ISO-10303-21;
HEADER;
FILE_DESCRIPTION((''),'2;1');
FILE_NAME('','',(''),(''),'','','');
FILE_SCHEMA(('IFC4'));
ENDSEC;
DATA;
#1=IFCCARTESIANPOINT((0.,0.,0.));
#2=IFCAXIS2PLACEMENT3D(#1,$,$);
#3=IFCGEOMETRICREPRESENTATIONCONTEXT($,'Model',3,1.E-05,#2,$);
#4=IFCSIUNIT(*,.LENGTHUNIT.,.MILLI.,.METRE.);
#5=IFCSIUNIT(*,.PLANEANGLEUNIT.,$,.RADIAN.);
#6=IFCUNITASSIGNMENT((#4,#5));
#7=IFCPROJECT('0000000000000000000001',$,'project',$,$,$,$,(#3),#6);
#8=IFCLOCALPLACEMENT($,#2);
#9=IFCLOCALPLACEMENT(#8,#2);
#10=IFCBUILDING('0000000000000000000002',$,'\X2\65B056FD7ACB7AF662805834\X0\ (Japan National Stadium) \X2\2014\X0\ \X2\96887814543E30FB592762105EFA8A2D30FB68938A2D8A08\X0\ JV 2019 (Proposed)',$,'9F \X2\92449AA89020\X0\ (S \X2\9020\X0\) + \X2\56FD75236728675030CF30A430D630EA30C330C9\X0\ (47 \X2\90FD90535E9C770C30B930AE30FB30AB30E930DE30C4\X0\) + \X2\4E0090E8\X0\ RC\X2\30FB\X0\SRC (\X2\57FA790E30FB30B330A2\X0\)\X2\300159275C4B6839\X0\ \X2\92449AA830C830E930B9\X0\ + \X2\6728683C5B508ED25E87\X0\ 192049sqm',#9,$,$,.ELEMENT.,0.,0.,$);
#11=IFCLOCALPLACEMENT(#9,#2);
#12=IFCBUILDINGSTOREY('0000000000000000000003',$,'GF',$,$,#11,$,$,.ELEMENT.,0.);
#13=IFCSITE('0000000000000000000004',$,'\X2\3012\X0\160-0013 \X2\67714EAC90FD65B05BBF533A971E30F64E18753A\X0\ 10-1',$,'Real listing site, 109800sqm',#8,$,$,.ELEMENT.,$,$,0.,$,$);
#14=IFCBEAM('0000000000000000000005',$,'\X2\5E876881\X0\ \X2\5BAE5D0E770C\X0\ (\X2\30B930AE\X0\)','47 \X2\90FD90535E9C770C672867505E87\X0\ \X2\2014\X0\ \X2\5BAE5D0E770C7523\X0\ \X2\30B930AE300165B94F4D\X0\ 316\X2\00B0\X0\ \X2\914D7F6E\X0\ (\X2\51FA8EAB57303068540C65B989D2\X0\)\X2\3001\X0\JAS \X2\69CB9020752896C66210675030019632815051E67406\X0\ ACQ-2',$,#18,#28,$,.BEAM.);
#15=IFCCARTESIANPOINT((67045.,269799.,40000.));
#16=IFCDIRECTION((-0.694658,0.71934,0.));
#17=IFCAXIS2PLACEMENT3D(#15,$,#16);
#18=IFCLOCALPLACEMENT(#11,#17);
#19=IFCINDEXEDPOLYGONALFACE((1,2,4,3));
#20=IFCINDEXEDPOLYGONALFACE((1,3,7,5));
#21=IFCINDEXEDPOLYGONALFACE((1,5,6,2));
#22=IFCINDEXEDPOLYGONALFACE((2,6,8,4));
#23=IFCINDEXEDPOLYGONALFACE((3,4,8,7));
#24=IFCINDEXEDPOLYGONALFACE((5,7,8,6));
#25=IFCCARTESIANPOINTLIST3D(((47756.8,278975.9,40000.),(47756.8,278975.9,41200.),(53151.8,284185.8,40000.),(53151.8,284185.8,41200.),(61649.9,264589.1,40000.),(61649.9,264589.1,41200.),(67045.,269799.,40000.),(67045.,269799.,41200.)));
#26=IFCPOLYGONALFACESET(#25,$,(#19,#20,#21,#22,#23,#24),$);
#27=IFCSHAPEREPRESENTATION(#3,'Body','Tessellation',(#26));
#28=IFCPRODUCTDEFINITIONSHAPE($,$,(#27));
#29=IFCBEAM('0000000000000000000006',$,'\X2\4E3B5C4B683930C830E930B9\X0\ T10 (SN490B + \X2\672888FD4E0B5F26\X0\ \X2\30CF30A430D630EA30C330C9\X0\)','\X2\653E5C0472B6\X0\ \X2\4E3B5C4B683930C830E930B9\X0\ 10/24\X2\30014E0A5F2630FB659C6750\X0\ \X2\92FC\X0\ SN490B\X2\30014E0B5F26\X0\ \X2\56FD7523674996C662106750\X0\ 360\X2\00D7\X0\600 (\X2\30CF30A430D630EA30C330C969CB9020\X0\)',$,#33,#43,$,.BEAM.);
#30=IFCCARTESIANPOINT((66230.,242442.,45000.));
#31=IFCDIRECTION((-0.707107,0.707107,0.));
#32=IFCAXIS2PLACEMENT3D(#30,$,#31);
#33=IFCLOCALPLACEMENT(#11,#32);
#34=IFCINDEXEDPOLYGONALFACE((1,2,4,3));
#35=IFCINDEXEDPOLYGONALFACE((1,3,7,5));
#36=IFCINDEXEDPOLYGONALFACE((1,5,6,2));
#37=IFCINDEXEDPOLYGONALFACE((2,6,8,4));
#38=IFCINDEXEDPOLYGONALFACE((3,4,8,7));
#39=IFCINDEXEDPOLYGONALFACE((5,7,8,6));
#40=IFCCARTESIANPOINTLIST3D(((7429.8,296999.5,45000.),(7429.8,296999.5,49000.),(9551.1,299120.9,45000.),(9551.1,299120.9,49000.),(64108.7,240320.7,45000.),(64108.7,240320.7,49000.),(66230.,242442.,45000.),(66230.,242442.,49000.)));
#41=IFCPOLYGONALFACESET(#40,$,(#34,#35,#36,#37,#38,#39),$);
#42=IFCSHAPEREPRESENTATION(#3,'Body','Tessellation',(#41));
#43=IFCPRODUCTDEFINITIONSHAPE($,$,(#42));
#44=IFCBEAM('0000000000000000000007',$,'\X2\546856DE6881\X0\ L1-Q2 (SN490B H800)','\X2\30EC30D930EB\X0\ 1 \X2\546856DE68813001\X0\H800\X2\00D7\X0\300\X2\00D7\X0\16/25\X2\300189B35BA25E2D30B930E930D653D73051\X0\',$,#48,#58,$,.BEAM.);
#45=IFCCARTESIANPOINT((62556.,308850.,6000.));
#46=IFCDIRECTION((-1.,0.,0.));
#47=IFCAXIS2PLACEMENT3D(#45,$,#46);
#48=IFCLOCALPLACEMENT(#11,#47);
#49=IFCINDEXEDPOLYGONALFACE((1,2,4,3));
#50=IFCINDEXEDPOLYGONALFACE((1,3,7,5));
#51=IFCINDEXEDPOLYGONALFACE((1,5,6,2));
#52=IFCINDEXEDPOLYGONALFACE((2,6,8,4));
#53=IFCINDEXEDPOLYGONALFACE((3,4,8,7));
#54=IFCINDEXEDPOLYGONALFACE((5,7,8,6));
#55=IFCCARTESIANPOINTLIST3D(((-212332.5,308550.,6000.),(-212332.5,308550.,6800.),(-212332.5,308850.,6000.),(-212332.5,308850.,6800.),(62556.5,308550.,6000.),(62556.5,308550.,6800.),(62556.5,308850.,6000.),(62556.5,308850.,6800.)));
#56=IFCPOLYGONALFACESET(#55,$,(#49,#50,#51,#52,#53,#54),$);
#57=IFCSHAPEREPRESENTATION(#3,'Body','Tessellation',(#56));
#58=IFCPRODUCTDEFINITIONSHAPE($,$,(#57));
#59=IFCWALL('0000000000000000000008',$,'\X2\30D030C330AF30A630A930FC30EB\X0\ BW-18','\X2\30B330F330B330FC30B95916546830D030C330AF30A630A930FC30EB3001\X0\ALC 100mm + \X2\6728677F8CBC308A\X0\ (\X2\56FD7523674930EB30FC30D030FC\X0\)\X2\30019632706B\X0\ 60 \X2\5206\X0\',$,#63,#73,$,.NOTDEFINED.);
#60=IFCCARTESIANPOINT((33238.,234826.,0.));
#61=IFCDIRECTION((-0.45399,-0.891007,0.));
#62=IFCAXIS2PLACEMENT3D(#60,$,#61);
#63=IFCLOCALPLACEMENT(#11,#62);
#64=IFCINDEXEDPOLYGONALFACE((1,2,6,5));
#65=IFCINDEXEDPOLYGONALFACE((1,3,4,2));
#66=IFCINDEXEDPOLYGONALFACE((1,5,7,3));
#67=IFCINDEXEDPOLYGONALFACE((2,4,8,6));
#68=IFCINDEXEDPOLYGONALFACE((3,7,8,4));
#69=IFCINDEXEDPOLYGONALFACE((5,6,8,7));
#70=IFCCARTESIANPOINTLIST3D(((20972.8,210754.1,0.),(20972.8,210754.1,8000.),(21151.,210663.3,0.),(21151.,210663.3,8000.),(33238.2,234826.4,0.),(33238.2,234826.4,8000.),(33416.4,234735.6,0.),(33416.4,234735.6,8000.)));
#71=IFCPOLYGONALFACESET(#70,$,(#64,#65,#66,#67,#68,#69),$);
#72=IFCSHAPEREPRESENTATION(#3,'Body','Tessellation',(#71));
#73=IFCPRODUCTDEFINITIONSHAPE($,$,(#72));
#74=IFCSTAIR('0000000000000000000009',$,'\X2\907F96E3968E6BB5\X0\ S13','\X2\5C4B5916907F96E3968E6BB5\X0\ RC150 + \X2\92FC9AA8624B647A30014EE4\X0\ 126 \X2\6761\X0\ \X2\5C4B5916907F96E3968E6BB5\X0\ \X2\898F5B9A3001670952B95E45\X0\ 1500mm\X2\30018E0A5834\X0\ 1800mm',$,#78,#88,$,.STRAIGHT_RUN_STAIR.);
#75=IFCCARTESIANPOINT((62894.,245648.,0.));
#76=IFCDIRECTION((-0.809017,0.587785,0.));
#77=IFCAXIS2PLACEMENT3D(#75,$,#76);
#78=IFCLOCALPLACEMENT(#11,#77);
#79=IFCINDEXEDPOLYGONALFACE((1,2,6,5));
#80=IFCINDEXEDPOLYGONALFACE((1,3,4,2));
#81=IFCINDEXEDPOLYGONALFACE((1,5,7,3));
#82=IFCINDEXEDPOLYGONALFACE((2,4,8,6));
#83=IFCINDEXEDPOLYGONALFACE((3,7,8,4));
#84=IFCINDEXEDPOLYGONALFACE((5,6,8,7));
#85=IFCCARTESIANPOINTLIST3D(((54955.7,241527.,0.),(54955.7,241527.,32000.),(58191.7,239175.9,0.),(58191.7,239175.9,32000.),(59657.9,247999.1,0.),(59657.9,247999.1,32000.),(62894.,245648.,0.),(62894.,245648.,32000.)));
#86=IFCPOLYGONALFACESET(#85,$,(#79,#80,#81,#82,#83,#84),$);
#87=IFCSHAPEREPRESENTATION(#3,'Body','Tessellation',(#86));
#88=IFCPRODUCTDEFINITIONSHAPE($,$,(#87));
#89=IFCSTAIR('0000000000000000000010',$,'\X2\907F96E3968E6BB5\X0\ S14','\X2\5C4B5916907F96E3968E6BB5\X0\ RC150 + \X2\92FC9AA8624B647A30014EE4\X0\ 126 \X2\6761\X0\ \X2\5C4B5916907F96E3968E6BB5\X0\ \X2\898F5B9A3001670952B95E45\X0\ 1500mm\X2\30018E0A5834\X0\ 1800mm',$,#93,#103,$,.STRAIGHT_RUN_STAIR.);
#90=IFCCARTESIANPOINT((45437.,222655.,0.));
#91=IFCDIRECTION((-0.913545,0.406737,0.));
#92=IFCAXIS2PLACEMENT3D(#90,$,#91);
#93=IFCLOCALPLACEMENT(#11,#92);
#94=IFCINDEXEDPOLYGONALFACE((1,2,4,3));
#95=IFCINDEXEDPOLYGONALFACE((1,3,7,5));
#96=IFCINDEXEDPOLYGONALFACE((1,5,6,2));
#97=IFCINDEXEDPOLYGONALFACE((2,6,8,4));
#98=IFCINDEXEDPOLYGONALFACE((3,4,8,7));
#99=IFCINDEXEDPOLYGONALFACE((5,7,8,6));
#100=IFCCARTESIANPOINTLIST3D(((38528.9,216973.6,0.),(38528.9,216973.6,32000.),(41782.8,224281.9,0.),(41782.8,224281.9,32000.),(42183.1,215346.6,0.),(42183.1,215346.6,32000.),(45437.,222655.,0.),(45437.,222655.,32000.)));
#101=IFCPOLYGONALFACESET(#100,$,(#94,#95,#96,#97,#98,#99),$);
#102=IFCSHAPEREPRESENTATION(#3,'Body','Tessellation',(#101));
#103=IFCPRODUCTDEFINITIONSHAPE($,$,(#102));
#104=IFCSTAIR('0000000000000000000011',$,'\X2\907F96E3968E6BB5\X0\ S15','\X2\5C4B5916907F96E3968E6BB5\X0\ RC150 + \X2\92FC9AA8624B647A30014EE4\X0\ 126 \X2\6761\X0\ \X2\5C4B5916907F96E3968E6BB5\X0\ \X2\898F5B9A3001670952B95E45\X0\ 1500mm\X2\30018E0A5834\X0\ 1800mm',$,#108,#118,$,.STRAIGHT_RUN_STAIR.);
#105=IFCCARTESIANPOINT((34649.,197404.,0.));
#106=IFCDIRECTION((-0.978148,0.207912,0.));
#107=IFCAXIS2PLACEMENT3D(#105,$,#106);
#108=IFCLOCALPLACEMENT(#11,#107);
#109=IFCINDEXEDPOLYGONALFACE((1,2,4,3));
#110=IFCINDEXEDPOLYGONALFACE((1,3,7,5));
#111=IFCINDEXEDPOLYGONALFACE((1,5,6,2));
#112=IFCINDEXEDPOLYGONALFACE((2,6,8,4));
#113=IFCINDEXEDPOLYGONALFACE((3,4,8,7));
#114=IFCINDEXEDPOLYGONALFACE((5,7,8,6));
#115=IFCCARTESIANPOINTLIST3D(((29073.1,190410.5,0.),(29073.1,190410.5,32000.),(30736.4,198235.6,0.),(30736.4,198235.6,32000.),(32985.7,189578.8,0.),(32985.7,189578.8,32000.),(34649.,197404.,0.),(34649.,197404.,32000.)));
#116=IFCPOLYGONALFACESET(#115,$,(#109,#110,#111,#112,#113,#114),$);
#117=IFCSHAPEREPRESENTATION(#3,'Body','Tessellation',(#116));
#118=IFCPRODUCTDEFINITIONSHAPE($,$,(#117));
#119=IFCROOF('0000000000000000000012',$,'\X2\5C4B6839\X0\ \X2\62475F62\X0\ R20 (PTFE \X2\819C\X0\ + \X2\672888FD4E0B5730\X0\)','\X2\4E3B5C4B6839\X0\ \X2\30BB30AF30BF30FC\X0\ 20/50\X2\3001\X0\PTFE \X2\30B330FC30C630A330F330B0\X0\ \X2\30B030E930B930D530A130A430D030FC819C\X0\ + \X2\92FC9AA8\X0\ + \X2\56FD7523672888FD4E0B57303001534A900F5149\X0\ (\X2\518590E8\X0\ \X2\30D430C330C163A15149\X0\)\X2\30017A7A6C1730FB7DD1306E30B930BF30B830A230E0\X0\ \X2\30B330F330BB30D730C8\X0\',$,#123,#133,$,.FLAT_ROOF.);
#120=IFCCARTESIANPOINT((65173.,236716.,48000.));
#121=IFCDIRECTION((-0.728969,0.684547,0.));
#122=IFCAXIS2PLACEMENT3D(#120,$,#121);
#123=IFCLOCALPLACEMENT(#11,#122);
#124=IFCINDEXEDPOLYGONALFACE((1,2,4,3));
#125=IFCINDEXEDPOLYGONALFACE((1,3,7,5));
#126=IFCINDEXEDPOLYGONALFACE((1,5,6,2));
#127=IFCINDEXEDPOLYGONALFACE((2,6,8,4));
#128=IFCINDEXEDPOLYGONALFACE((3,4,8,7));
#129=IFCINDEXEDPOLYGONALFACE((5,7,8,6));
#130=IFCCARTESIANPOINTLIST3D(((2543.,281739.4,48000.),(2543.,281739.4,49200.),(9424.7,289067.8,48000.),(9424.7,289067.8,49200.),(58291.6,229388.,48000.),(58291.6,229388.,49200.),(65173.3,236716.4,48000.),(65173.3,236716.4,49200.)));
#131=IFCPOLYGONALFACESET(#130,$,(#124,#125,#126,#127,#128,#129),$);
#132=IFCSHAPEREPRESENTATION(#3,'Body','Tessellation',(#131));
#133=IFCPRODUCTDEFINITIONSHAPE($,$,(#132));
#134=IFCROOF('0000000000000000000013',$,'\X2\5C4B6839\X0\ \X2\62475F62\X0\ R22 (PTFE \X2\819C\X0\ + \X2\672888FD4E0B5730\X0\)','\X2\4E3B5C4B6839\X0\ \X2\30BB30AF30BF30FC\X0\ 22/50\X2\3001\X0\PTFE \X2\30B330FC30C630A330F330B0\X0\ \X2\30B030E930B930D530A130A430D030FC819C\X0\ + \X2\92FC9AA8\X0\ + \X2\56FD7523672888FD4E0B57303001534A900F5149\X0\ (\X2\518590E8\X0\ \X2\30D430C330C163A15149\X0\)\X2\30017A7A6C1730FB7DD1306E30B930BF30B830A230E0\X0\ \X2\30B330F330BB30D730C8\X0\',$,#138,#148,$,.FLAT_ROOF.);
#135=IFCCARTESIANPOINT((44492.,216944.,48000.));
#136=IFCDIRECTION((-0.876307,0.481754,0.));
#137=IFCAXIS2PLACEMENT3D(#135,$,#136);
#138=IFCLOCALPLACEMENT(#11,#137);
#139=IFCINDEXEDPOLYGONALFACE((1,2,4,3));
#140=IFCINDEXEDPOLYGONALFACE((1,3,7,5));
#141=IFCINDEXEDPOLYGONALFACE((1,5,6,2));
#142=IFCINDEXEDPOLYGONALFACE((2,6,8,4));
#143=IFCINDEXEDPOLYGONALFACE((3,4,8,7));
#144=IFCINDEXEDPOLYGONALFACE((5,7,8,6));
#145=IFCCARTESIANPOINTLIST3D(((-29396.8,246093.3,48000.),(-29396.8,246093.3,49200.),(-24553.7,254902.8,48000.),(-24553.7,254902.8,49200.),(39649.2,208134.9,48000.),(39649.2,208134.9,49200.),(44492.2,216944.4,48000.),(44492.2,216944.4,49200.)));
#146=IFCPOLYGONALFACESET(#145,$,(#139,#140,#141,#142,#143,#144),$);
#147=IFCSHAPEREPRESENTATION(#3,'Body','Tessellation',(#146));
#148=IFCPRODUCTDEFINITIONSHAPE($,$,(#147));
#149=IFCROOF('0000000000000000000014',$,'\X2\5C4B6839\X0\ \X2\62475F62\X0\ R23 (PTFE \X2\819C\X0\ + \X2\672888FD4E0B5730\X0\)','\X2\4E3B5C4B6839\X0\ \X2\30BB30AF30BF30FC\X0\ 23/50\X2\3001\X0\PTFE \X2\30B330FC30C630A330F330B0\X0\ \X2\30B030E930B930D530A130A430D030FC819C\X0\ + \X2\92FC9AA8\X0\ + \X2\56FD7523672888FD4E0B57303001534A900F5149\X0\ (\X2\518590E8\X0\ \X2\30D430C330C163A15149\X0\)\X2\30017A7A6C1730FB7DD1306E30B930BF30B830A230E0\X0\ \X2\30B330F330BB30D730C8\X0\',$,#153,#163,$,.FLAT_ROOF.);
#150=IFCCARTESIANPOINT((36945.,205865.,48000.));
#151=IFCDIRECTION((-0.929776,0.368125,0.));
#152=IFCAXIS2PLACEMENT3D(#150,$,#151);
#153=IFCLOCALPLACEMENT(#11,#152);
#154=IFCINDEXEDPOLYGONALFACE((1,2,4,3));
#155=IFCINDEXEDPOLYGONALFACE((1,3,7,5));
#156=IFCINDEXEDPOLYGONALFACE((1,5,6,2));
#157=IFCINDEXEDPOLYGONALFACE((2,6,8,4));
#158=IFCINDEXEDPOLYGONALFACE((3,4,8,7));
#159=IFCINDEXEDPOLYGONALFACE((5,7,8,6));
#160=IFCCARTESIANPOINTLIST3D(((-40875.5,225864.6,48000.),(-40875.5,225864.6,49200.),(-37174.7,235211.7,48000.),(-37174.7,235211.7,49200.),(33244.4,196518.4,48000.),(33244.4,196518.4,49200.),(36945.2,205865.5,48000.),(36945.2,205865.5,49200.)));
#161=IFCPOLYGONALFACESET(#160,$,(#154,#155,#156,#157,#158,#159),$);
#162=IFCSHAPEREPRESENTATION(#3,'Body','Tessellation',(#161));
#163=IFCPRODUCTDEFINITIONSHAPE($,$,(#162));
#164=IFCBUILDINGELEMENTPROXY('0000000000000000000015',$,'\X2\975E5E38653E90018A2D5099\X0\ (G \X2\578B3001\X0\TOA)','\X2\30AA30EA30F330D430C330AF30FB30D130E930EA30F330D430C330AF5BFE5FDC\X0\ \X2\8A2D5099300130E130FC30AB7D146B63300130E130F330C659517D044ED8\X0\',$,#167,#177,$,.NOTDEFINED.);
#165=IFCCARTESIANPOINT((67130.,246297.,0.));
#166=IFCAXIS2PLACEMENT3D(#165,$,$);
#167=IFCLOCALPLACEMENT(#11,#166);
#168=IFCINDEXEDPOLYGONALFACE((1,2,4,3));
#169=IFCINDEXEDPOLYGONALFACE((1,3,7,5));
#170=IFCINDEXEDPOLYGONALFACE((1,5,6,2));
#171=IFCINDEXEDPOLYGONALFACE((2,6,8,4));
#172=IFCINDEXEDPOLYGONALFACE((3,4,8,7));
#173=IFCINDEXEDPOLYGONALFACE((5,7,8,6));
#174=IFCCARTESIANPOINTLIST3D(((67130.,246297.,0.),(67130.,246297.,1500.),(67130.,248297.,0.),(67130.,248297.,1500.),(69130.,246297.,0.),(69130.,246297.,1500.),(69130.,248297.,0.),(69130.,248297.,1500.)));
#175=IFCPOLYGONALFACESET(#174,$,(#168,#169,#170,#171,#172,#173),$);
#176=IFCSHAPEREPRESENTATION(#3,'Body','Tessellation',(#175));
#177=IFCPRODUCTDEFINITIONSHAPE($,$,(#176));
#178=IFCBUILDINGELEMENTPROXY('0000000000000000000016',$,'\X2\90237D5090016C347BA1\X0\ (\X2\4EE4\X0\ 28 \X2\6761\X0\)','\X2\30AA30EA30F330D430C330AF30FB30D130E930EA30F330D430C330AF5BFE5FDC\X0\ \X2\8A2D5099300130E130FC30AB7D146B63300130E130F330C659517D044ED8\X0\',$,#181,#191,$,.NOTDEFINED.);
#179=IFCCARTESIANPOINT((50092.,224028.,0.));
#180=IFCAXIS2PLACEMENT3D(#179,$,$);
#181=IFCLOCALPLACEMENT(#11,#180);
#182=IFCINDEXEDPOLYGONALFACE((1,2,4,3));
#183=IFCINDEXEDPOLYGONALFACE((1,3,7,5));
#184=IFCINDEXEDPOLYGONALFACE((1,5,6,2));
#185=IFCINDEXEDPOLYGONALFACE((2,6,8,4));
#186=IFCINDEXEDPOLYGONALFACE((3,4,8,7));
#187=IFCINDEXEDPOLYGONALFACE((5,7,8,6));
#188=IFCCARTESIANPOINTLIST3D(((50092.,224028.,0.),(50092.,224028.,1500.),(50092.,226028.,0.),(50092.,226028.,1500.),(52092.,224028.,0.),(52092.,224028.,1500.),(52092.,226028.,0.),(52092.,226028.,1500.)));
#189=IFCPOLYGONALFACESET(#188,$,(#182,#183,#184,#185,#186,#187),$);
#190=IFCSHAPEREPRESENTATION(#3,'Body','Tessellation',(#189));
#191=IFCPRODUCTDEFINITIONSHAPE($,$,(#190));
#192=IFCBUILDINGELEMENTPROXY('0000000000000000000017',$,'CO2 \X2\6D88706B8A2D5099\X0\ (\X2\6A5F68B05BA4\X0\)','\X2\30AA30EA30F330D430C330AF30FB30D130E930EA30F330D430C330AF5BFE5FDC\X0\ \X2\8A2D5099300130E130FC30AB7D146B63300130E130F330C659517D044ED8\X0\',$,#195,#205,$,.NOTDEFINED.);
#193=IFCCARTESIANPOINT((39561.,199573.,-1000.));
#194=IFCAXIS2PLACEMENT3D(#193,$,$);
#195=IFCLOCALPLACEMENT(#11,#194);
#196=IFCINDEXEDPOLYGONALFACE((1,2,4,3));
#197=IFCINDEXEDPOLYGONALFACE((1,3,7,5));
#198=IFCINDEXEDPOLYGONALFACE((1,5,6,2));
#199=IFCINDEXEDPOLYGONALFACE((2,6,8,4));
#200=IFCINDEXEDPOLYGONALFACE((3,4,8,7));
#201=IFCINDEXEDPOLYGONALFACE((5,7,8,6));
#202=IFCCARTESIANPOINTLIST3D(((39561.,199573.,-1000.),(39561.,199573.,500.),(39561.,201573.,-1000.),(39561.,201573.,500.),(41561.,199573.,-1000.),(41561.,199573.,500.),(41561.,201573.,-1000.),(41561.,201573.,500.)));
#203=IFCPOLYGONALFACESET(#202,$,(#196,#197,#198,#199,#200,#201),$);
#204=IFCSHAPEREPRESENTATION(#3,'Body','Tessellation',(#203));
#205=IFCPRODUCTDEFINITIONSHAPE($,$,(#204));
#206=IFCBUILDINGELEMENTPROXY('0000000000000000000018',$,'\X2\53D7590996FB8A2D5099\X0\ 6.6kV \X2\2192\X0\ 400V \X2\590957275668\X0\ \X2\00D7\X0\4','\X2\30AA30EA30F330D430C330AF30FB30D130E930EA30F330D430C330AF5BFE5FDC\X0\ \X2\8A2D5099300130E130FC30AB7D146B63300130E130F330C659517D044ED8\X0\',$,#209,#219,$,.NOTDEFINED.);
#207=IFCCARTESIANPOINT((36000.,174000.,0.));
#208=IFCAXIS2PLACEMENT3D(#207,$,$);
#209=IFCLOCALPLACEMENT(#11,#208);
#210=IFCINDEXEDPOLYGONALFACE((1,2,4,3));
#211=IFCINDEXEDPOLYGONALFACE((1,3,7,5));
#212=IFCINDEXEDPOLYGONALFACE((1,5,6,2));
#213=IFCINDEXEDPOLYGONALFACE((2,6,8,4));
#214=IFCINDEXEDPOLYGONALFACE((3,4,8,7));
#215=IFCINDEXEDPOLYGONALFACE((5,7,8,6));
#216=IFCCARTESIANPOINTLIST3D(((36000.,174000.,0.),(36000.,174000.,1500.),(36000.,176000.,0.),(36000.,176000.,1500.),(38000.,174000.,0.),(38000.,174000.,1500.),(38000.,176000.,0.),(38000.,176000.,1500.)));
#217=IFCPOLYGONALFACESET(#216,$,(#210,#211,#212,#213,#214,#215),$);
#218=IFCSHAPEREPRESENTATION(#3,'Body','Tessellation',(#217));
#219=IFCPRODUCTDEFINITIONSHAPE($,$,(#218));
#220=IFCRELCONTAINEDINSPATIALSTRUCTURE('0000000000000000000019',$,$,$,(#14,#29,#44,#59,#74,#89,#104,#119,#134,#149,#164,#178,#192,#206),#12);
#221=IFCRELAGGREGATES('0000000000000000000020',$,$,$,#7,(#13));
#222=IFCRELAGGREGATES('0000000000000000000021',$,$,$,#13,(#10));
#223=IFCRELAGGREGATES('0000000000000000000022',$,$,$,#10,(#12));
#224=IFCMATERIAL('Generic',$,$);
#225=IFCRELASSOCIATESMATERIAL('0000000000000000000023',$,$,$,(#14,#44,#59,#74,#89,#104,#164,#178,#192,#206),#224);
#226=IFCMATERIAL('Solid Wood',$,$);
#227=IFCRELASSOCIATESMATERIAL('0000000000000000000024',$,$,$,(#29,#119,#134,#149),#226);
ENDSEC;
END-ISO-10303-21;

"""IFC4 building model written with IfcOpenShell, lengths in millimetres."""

from ifc_helpers import new_model, si_unit, frame, frame_2d, origin, place, context, project, spatial, rectangle, extrude, material, element, save


model = new_model("IFC4")

# Units and contexts
model_context = context("Model", 3, precision=1e-05, world=origin())
ifc_project = project(units=[si_unit("LENGTHUNIT", "METRE", prefix="MILLI"), si_unit("PLANEANGLEUNIT", "RADIAN")], contexts=[model_context])

# Site, building, storey
site_placement = place(None, origin())
site = spatial("IfcSite", under=ifc_project, at=site_placement, Name="〒160-0013 東京都新宿区霞ヶ丘町 10-1", ObjectType="Real listing site, 109800sqm", CompositionType="ELEMENT", RefElevation=0.0)
building_placement = place(site_placement, origin())
building = spatial("IfcBuilding", under=site, at=building_placement, Name="新国立競技場 (Japan National Stadium) — 隈研吾・大成建設・梓設計 JV 2019 (Proposed)", ObjectType="9F 鉄骨造 (S 造) + 国産木材ハイブリッド (47 都道府県スギ・カラマツ) + 一部 RC・SRC (基礎・コア)、大屋根 鉄骨トラス + 木格子軒庇 192049sqm", CompositionType="ELEMENT", ElevationOfRefHeight=0.0, ElevationOfTerrain=0.0)
storey_placement = place(building_placement, origin())
storey = spatial("IfcBuildingStorey", under=building, at=storey_placement, Name="GF", CompositionType="ELEMENT", Elevation=0.0)

# Shared definitions
ifc_material_1 = material(Name="Generic")

# Beams
beam_1_placement = place(storey_placement, frame((67045.0, 269799.0, 40000.0), x_axis=(-0.694658, 0.71934, 0.0)))
element("IfcBeam", 1, at=beam_1_placement, inside=storey, material=ifc_material_1, Name="庇梁 宮崎県 (スギ)", Description="47 都道府県木材庇 — 宮崎県産 スギ、方位 316° 配置 (出身地と同方角)、JAS 構造用集成材、防腐処理 ACQ-2", PredefinedType="BEAM", context=model_context, shape_type="SweptSolid", body=[
    extrude(rectangle(XDim=20000.0, YDim=7500.0, at=frame_2d((10000.0, 3750.0))), frame((67045.0, 269799.0, 40000.0), x_axis=(-0.694658, 0.71934, 0.0)), (0.0, 0.0, 1.0), 1200.0),
])
ifc_material_2 = material(Name="Solid Wood")
beam_2_placement = place(storey_placement, frame((66230.0, 242442.0, 45000.0), x_axis=(-0.707107, 0.707107, 0.0)))
element("IfcBeam", 2, at=beam_2_placement, inside=storey, material=ifc_material_2, Name="主屋根トラス T10 (SN490B + 木製下弦 ハイブリッド)", Description="放射状 主屋根トラス 10/24、上弦・斜材 鋼 SN490B、下弦 国産杉集成材 360×600 (ハイブリッド構造)", PredefinedType="BEAM", context=model_context, shape_type="SweptSolid", body=[
    extrude(rectangle(XDim=80156.0, YDim=3000.0, at=frame_2d((40078.0, 1500.0))), frame((66230.0, 242442.0, 45000.0), x_axis=(-0.707107, 0.707107, 0.0)), (0.0, 0.0, 1.0), 4000.0),
])
beam_3_placement = place(storey_placement, frame((62556.0, 308850.0, 6000.0), x_axis=(-1.0, 0.0, 0.0)))
element("IfcBeam", 3, at=beam_3_placement, inside=storey, material=ifc_material_1, Name="周回梁 L1-Q2 (SN490B H800)", Description="レベル 1 周回梁、H800×300×16/25、観客席スラブ受け", PredefinedType="BEAM", context=model_context, shape_type="SweptSolid", body=[
    extrude(rectangle(XDim=274889.0, YDim=300.0, at=frame_2d((137444.0, 150.0))), frame((62556.0, 308850.0, 6000.0), x_axis=(-1.0, 0.0, 0.0)), (0.0, 0.0, 1.0), 800.0),
])

# Wall
wall_1_placement = place(storey_placement, frame((33238.0, 234826.0, 0.0), x_axis=(-0.45399, -0.891007, 0.0)))
element("IfcWall", 4, at=wall_1_placement, inside=storey, material=ifc_material_1, Name="バックウォール BW-18", Description="コンコース外周バックウォール、ALC 100mm + 木板貼り (国産杉ルーバー)、防火 60 分", PredefinedType="NOTDEFINED", context=model_context, shape_type="SweptSolid", body=[
    extrude(rectangle(XDim=27017.0, YDim=200.0, at=frame_2d((13508.0, 100.0))), frame((33238.0, 234826.0, 0.0), x_axis=(-0.45399, -0.891007, 0.0)), (0.0, 0.0, 1.0), 8000.0),
])

# Stairs
stair_1_placement = place(storey_placement, frame((62894.0, 245648.0, 0.0), x_axis=(-0.809017, 0.587785, 0.0)))
element("IfcStair", 5, at=stair_1_placement, inside=storey, material=ifc_material_1, Name="避難階段 S13", Description="屋外避難階段 RC150 + 鋼骨手摺、令 126 条 屋外避難階段 規定、有効幅 1500mm、踊場 1800mm", PredefinedType="STRAIGHT_RUN_STAIR", context=model_context, shape_type="SweptSolid", body=[
    extrude(rectangle(XDim=4000.0, YDim=8000.0, at=frame_2d((2000.0, 4000.0))), frame((62894.0, 245648.0, 0.0), x_axis=(-0.809017, 0.587785, 0.0)), (0.0, 0.0, 1.0), 32000.0),
])
stair_2_placement = place(storey_placement, frame((45437.0, 222655.0, 0.0), x_axis=(-0.913545, 0.406737, 0.0)))
element("IfcStair", 6, at=stair_2_placement, inside=storey, material=ifc_material_1, Name="避難階段 S14", Description="屋外避難階段 RC150 + 鋼骨手摺、令 126 条 屋外避難階段 規定、有効幅 1500mm、踊場 1800mm", PredefinedType="STRAIGHT_RUN_STAIR", context=model_context, shape_type="SweptSolid", body=[
    extrude(rectangle(XDim=4000.0, YDim=8000.0, at=frame_2d((2000.0, 4000.0))), frame((45437.0, 222655.0, 0.0), x_axis=(-0.913545, 0.406737, 0.0)), (0.0, 0.0, 1.0), 32000.0),
])
stair_3_placement = place(storey_placement, frame((34649.0, 197404.0, 0.0), x_axis=(-0.978148, 0.207912, 0.0)))
element("IfcStair", 7, at=stair_3_placement, inside=storey, material=ifc_material_1, Name="避難階段 S15", Description="屋外避難階段 RC150 + 鋼骨手摺、令 126 条 屋外避難階段 規定、有効幅 1500mm、踊場 1800mm", PredefinedType="STRAIGHT_RUN_STAIR", context=model_context, shape_type="SweptSolid", body=[
    extrude(rectangle(XDim=4000.0, YDim=8000.0, at=frame_2d((2000.0, 4000.0))), frame((34649.0, 197404.0, 0.0), x_axis=(-0.978148, 0.207912, 0.0)), (0.0, 0.0, 1.0), 32000.0),
])

# Roofs
roof_1_placement = place(storey_placement, frame((65173.0, 236716.0, 48000.0), x_axis=(-0.728969, 0.684547, 0.0)))
element("IfcRoof", 8, at=roof_1_placement, inside=storey, material=ifc_material_2, Name="屋根 扇形 R20 (PTFE 膜 + 木製下地)", Description="主屋根 セクター 20/50、PTFE コーティング グラスファイバー膜 + 鋼骨 + 国産木製下地、半透光 (内部 ピッチ採光)、空気・緑のスタジアム コンセプト", PredefinedType="FLAT_ROOF", context=model_context, shape_type="SweptSolid", body=[
    extrude(rectangle(XDim=76476.0, YDim=10053.0, at=frame_2d((38238.0, 5026.0))), frame((65173.0, 236716.0, 48000.0), x_axis=(-0.728969, 0.684547, 0.0)), (0.0, 0.0, 1.0), 1200.0),
])
roof_2_placement = place(storey_placement, frame((44492.0, 216944.0, 48000.0), x_axis=(-0.876307, 0.481754, 0.0)))
element("IfcRoof", 9, at=roof_2_placement, inside=storey, material=ifc_material_2, Name="屋根 扇形 R22 (PTFE 膜 + 木製下地)", Description="主屋根 セクター 22/50、PTFE コーティング グラスファイバー膜 + 鋼骨 + 国産木製下地、半透光 (内部 ピッチ採光)、空気・緑のスタジアム コンセプト", PredefinedType="FLAT_ROOF", context=model_context, shape_type="SweptSolid", body=[
    extrude(rectangle(XDim=78792.0, YDim=10053.0, at=frame_2d((39396.0, 5026.0))), frame((44492.0, 216944.0, 48000.0), x_axis=(-0.876307, 0.481754, 0.0)), (0.0, 0.0, 1.0), 1200.0),
])
roof_3_placement = place(storey_placement, frame((36945.0, 205865.0, 48000.0), x_axis=(-0.929776, 0.368125, 0.0)))
element("IfcRoof", 10, at=roof_3_placement, inside=storey, material=ifc_material_2, Name="屋根 扇形 R23 (PTFE 膜 + 木製下地)", Description="主屋根 セクター 23/50、PTFE コーティング グラスファイバー膜 + 鋼骨 + 国産木製下地、半透光 (内部 ピッチ採光)、空気・緑のスタジアム コンセプト", PredefinedType="FLAT_ROOF", context=model_context, shape_type="SweptSolid", body=[
    extrude(rectangle(XDim=79718.0, YDim=10053.0, at=frame_2d((39859.0, 5026.0))), frame((36945.0, 205865.0, 48000.0), x_axis=(-0.929776, 0.368125, 0.0)), (0.0, 0.0, 1.0), 1200.0),
])

# Building element proxies
proxy_1_placement = place(storey_placement, frame((67130.0, 246297.0, 0.0)))
element("IfcBuildingElementProxy", 11, at=proxy_1_placement, inside=storey, material=ifc_material_1, Name="非常放送設備 (G 型、TOA)", Description="オリンピック・パラリンピック対応 設備、メーカ純正、メンテ契約付", PredefinedType="NOTDEFINED", context=model_context, shape_type="SweptSolid", body=[
    extrude(rectangle(XDim=2000.0, YDim=2000.0, at=frame_2d((1000.0, 1000.0))), frame((67130.0, 246297.0, 0.0)), (0.0, 0.0, 1.0), 1500.0),
])
proxy_2_placement = place(storey_placement, frame((50092.0, 224028.0, 0.0)))
element("IfcBuildingElementProxy", 12, at=proxy_2_placement, inside=storey, material=ifc_material_1, Name="連結送水管 (令 28 条)", Description="オリンピック・パラリンピック対応 設備、メーカ純正、メンテ契約付", PredefinedType="NOTDEFINED", context=model_context, shape_type="SweptSolid", body=[
    extrude(rectangle(XDim=2000.0, YDim=2000.0, at=frame_2d((1000.0, 1000.0))), frame((50092.0, 224028.0, 0.0)), (0.0, 0.0, 1.0), 1500.0),
])
proxy_3_placement = place(storey_placement, frame((39561.0, 199573.0, -1000.0)))
element("IfcBuildingElementProxy", 13, at=proxy_3_placement, inside=storey, material=ifc_material_1, Name="CO2 消火設備 (機械室)", Description="オリンピック・パラリンピック対応 設備、メーカ純正、メンテ契約付", PredefinedType="NOTDEFINED", context=model_context, shape_type="SweptSolid", body=[
    extrude(rectangle(XDim=2000.0, YDim=2000.0, at=frame_2d((1000.0, 1000.0))), frame((39561.0, 199573.0, -1000.0)), (0.0, 0.0, 1.0), 1500.0),
])
proxy_4_placement = place(storey_placement, frame((36000.0, 174000.0, 0.0)))
element("IfcBuildingElementProxy", 14, at=proxy_4_placement, inside=storey, material=ifc_material_1, Name="受変電設備 6.6kV → 400V 変圧器 ×4", Description="オリンピック・パラリンピック対応 設備、メーカ純正、メンテ契約付", PredefinedType="NOTDEFINED", context=model_context, shape_type="SweptSolid", body=[
    extrude(rectangle(XDim=2000.0, YDim=2000.0, at=frame_2d((1000.0, 1000.0))), frame((36000.0, 174000.0, 0.0)), (0.0, 0.0, 1.0), 1500.0),
])

save(model, "model.ifc")
